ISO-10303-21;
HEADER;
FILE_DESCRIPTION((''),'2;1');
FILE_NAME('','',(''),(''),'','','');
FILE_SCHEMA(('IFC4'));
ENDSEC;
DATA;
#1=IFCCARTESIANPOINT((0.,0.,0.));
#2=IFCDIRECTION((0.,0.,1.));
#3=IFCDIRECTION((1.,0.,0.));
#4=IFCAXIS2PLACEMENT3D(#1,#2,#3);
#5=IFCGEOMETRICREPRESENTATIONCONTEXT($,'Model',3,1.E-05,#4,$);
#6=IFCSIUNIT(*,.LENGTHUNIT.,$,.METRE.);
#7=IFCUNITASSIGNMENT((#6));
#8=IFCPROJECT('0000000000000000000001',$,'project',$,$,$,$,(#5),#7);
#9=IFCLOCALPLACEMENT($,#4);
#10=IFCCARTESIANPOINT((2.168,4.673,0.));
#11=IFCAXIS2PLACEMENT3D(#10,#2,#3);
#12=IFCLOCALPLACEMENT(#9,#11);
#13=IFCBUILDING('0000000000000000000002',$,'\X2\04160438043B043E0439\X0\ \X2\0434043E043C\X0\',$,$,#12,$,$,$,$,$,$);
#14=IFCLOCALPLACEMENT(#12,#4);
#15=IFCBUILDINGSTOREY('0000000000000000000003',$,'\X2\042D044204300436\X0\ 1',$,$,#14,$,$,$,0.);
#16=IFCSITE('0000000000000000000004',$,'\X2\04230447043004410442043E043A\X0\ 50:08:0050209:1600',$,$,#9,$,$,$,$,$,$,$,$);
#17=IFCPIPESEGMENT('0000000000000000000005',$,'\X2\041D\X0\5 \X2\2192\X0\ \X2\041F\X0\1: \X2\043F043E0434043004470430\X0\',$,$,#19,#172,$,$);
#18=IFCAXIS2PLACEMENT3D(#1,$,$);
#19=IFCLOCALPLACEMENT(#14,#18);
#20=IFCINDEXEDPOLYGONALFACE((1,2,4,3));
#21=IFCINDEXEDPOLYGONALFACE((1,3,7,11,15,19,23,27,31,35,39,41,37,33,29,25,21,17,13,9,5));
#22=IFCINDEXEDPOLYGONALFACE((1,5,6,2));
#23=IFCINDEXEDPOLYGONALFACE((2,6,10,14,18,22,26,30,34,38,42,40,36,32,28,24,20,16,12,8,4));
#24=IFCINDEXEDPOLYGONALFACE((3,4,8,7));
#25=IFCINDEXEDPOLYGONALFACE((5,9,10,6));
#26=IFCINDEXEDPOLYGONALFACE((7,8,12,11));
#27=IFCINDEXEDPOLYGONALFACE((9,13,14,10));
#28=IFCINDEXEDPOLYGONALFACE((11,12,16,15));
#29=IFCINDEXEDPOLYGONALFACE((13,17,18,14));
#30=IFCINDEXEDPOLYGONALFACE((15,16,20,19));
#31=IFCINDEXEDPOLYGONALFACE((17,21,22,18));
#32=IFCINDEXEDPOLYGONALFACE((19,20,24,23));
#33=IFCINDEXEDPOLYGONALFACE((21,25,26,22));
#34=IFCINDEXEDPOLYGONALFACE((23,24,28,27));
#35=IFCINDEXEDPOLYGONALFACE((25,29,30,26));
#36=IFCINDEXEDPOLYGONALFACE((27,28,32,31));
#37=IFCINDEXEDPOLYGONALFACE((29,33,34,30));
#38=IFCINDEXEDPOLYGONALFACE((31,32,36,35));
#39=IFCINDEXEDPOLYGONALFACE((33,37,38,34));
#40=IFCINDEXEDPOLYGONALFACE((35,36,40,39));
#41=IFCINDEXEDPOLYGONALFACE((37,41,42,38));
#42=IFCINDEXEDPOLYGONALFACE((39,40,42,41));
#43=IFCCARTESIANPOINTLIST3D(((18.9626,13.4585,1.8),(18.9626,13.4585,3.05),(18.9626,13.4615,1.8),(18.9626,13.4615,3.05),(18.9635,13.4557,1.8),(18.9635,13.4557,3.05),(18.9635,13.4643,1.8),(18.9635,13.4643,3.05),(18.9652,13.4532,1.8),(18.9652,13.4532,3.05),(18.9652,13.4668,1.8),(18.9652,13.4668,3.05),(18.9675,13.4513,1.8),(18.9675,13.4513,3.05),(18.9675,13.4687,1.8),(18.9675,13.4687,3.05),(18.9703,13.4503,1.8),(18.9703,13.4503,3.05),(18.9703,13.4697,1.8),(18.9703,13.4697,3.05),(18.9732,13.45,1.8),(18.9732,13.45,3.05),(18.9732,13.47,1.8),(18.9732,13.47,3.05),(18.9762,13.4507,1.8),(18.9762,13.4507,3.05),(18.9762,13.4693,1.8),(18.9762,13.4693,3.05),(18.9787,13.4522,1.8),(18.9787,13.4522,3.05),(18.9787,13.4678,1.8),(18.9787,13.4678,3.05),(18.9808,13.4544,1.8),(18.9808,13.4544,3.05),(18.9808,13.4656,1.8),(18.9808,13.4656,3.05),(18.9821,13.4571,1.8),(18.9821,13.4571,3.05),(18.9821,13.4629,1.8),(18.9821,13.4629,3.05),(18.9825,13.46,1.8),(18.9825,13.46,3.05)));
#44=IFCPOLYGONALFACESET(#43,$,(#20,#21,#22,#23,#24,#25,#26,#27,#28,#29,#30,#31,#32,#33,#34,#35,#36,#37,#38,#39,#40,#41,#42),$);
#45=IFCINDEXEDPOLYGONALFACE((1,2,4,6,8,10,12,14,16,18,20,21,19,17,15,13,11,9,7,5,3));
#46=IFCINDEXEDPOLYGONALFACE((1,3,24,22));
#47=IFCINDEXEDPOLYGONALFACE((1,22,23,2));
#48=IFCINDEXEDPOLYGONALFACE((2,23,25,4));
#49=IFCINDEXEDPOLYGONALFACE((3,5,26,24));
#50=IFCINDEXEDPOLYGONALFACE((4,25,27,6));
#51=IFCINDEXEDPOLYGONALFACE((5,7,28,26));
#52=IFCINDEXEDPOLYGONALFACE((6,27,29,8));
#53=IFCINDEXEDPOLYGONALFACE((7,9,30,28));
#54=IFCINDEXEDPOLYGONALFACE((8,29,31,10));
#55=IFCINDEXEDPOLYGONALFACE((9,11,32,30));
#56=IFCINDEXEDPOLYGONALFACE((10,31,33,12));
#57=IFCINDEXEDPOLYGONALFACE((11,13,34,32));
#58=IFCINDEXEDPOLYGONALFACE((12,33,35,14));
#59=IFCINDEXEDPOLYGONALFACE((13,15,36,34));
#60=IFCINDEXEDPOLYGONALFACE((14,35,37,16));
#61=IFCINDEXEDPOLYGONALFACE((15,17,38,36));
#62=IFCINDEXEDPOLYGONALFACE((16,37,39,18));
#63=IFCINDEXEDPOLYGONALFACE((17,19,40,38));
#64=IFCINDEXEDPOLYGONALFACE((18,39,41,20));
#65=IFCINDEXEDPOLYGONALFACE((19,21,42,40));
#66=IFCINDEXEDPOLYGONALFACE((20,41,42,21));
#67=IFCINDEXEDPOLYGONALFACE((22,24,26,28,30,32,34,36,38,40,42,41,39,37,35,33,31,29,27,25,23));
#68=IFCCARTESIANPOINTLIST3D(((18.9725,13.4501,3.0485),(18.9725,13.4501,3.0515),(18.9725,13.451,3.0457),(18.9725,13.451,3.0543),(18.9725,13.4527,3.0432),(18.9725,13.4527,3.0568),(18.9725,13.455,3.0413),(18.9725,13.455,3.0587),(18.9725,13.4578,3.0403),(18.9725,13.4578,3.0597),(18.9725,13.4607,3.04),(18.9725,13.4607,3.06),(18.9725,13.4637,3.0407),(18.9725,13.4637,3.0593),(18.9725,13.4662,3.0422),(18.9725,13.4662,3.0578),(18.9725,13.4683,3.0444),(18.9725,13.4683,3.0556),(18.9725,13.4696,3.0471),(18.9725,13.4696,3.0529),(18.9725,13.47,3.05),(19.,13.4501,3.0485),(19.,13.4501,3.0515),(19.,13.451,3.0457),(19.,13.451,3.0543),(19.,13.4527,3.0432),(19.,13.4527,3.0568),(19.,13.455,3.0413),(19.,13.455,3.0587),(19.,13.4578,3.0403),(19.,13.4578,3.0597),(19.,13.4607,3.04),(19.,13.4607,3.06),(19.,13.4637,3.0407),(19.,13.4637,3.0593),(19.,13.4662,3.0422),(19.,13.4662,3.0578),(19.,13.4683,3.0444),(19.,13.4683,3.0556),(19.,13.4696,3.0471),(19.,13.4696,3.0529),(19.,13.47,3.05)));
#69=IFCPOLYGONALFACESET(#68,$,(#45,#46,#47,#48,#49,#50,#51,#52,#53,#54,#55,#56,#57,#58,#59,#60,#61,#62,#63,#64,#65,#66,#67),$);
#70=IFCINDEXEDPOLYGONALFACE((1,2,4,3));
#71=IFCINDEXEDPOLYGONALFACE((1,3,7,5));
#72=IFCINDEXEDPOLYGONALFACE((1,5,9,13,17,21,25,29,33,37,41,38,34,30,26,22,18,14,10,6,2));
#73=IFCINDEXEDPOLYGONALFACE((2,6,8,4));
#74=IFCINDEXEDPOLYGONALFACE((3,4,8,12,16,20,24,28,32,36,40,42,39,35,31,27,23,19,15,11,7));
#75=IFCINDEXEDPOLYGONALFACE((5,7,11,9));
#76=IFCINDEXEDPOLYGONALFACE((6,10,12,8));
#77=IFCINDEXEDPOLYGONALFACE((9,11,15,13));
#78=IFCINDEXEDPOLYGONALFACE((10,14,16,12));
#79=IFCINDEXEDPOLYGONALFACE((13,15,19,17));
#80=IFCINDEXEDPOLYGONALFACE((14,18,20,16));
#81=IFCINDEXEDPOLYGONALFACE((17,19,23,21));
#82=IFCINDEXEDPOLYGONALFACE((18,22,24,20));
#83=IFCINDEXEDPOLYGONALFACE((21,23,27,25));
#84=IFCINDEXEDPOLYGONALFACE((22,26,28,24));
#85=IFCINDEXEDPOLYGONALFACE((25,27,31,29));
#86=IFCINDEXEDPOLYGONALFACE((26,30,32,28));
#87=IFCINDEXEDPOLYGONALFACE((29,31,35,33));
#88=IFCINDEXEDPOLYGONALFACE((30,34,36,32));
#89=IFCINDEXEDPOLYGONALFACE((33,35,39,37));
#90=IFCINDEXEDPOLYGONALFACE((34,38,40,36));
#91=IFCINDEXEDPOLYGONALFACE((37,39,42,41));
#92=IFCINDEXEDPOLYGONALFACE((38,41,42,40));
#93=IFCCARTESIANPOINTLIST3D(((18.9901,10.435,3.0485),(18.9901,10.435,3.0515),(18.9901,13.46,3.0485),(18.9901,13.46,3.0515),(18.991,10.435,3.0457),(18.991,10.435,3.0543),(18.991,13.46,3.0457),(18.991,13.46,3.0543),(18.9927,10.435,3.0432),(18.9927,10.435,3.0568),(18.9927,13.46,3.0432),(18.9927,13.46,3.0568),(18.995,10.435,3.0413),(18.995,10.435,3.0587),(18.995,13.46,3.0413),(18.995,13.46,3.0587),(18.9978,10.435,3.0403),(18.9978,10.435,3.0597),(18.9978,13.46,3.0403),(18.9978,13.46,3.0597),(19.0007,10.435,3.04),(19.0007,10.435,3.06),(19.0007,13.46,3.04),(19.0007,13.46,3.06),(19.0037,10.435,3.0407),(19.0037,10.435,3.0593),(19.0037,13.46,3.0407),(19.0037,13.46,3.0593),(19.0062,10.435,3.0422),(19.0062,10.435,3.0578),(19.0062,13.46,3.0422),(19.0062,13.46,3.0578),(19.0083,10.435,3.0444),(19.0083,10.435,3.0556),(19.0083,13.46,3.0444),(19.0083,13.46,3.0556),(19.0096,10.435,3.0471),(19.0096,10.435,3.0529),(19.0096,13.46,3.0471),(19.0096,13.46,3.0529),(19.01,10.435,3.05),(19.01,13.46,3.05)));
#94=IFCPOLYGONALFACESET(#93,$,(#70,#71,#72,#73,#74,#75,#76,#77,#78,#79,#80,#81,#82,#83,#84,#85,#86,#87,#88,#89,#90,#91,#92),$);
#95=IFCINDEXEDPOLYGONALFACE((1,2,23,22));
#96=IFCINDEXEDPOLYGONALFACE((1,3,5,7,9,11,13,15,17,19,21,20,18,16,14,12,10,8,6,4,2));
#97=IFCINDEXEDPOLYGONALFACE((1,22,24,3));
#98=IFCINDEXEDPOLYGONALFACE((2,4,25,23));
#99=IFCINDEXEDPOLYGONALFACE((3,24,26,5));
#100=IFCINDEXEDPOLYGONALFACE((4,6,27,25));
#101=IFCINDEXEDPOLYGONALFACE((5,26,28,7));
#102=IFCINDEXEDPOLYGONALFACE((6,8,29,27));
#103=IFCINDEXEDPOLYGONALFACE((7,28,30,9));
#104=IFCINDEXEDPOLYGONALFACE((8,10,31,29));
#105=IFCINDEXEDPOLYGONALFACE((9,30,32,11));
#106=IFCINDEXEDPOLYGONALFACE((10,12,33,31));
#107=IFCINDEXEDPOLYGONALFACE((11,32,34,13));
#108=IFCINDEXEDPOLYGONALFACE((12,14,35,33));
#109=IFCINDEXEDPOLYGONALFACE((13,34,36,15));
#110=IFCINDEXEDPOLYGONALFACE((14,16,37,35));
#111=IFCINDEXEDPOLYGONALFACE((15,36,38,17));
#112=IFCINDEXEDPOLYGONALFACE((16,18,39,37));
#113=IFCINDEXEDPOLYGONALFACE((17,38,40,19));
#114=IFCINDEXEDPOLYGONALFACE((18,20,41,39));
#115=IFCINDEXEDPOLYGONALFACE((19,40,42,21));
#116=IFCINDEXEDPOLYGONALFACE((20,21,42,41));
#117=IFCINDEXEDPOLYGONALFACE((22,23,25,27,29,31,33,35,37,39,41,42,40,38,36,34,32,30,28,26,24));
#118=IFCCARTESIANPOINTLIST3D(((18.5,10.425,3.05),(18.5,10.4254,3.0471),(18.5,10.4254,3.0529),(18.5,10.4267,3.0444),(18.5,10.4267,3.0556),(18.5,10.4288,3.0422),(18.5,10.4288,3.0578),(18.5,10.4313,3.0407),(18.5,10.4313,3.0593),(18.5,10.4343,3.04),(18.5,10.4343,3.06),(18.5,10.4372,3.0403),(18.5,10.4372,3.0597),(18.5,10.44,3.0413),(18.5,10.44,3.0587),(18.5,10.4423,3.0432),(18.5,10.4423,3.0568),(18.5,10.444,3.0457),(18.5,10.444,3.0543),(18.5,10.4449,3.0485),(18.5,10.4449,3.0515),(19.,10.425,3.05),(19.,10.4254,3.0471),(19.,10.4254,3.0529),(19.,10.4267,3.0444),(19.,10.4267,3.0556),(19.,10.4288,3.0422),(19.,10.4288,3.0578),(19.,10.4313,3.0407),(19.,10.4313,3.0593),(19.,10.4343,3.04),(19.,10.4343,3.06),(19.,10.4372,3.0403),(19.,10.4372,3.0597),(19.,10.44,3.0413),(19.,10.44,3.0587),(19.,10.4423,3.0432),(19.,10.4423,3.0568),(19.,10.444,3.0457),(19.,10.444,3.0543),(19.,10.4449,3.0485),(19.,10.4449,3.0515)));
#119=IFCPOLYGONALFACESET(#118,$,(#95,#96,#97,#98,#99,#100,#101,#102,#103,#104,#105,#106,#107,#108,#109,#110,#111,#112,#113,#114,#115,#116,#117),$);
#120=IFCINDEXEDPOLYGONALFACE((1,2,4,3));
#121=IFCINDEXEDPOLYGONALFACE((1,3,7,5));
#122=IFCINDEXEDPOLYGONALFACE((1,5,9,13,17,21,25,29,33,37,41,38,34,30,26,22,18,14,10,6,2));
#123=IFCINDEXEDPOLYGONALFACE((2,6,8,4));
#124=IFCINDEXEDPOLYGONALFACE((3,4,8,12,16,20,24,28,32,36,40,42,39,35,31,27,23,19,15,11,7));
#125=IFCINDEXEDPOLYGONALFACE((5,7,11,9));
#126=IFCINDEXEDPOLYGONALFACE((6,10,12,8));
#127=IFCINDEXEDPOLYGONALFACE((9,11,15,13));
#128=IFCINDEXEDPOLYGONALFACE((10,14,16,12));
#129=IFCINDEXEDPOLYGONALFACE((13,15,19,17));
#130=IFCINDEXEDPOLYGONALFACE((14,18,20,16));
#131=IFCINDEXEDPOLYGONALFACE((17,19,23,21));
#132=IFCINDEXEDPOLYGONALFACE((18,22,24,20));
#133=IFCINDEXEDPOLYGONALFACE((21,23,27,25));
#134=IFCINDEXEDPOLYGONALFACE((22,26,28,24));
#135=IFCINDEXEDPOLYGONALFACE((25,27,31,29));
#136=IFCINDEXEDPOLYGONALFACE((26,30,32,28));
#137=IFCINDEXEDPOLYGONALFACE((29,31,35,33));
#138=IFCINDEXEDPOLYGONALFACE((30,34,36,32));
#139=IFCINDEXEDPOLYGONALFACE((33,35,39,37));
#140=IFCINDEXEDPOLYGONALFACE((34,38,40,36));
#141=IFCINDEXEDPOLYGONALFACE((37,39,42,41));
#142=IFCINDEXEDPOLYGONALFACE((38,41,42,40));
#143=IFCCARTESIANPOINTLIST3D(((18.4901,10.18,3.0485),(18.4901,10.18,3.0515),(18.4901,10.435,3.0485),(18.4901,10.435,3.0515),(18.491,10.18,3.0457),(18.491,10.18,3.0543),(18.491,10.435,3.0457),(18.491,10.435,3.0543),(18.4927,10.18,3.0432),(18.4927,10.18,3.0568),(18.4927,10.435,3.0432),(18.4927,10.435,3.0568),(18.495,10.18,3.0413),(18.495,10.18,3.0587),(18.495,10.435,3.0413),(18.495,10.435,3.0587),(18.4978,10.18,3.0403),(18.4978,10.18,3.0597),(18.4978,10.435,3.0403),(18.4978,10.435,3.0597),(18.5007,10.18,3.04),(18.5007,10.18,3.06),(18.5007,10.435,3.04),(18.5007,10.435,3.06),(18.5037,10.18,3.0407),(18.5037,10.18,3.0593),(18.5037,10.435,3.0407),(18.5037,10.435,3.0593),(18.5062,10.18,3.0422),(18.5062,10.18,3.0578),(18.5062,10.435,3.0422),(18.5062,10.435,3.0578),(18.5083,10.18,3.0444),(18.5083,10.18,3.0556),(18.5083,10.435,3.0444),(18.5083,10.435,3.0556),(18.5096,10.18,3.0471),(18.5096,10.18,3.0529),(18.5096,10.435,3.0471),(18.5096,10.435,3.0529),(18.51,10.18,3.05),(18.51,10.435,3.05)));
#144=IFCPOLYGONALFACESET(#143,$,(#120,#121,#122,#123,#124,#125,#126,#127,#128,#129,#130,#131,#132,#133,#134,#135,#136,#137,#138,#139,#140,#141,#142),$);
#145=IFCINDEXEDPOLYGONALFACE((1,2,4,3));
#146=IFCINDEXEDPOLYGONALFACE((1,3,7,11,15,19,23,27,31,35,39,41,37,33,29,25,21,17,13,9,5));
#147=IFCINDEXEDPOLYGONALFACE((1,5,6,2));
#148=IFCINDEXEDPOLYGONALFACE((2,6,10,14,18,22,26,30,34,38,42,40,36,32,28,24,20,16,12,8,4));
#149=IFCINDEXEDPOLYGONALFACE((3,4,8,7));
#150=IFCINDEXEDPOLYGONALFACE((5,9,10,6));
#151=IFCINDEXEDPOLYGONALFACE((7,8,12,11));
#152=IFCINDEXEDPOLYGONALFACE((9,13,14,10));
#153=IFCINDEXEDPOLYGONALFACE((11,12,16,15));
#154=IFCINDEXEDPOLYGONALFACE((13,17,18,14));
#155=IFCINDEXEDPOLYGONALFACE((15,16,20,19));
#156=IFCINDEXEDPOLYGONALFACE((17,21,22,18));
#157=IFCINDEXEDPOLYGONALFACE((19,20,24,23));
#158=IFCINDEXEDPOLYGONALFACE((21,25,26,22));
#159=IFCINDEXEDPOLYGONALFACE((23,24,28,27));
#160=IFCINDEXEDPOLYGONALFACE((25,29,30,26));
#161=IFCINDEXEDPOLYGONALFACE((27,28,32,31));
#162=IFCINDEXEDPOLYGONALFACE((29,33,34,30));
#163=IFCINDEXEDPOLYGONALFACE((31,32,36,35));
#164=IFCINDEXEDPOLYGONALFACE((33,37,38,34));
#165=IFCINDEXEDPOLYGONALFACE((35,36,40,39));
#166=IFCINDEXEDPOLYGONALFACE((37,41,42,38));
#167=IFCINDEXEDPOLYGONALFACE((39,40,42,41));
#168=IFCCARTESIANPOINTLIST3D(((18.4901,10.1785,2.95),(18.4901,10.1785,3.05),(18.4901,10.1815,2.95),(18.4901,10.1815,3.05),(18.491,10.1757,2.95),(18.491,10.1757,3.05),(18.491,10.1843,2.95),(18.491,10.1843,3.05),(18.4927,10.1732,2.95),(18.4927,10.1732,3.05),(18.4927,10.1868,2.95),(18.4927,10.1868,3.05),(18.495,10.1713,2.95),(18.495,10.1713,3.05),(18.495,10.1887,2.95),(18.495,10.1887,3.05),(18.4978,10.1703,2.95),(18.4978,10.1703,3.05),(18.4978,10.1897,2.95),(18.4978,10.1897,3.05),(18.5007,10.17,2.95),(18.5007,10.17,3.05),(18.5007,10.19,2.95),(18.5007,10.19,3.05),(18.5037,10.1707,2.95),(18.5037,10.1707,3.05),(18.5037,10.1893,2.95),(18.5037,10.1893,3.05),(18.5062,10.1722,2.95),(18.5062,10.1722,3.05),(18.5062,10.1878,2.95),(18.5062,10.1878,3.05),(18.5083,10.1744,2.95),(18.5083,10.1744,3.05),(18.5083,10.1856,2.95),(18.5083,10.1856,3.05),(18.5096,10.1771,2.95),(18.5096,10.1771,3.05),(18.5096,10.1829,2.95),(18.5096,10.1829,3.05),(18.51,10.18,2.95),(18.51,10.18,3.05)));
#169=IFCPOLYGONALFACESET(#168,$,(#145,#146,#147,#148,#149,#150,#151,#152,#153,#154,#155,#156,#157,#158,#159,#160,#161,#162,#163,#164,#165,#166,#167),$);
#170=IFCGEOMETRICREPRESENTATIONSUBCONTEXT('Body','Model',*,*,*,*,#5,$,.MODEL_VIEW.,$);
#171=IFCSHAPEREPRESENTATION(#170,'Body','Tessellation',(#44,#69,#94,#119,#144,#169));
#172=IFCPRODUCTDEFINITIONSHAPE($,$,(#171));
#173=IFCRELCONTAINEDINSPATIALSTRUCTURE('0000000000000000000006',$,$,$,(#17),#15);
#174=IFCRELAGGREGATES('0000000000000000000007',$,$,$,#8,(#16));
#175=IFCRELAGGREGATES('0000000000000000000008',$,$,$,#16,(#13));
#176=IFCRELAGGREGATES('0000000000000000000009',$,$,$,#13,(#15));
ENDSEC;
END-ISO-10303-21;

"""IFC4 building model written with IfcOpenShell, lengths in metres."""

from ifc_helpers import new_model, si_unit, frame, origin_with_axes, origin_2d, place, context, subcontext, project, spatial, circle, extrude, element, save


model = new_model("IFC4")

# Units and contexts
model_context = context("Model", 3, precision=1e-05, world=origin_with_axes())
body_context = subcontext(model_context, "Body", "Model", "MODEL_VIEW")
ifc_project = project(units=[si_unit("LENGTHUNIT", "METRE")], contexts=[model_context])

# Site, building, storey
site_placement = place(None, origin_with_axes())
site = spatial("IfcSite", under=ifc_project, at=site_placement, Name="Участок 50:08:0050209:1600")
building_placement = place(site_placement, frame((2.168, 4.673, 0.0), z_axis=(0.0, 0.0, 1.0), x_axis=(1.0, 0.0, 0.0)))
building = spatial("IfcBuilding", under=site, at=building_placement, Name="Жилой дом")
storey_placement = place(building_placement, origin_with_axes())
storey = spatial("IfcBuildingStorey", under=building, at=storey_placement, Name="Этаж 1", Elevation=0.0)

# Pipe segment
pipe_segment_1_placement = place(storey_placement, origin_with_axes())
element("IfcPipeSegment", 1, at=pipe_segment_1_placement, inside=storey, Name="Н5 → П1: подача", context=body_context, shape_type="SweptSolid", body=[
    extrude(circle(Radius=0.01, at=origin_2d()), frame((18.9725, 13.46, 1.8), z_axis=(0.0, 0.0, 1.0), x_axis=(1.0, 0.0, 0.0)), (0.0, 0.0, 1.0), 1.25),
    extrude(circle(Radius=0.01, at=origin_2d()), frame((18.9725, 13.46, 3.05), z_axis=(1.0, 0.0, 0.0), x_axis=(0.0, 1.0, 0.0)), (0.0, 0.0, 1.0), 0.0275),
    extrude(circle(Radius=0.01, at=origin_2d()), frame((19.0, 13.46, 3.05), z_axis=(0.0, -1.0, 0.0), x_axis=(1.0, 0.0, 0.0)), (0.0, 0.0, 1.0), 3.025),
    extrude(circle(Radius=0.01, at=origin_2d()), frame((19.0, 10.435, 3.05), z_axis=(-1.0, 0.0, 0.0), x_axis=(0.0, -1.0, 0.0)), (0.0, 0.0, 1.0), 0.5),
    extrude(circle(Radius=0.01, at=origin_2d()), frame((18.5, 10.435, 3.05), z_axis=(0.0, -1.0, 0.0), x_axis=(1.0, 0.0, 0.0)), (0.0, 0.0, 1.0), 0.255),
    extrude(circle(Radius=0.01, at=origin_2d()), frame((18.5, 10.18, 3.05), z_axis=(0.0, 0.0, -1.0), x_axis=(1.0, 0.0, 0.0)), (0.0, 0.0, 1.0), 0.1),
])

save(model, "model.ifc")
